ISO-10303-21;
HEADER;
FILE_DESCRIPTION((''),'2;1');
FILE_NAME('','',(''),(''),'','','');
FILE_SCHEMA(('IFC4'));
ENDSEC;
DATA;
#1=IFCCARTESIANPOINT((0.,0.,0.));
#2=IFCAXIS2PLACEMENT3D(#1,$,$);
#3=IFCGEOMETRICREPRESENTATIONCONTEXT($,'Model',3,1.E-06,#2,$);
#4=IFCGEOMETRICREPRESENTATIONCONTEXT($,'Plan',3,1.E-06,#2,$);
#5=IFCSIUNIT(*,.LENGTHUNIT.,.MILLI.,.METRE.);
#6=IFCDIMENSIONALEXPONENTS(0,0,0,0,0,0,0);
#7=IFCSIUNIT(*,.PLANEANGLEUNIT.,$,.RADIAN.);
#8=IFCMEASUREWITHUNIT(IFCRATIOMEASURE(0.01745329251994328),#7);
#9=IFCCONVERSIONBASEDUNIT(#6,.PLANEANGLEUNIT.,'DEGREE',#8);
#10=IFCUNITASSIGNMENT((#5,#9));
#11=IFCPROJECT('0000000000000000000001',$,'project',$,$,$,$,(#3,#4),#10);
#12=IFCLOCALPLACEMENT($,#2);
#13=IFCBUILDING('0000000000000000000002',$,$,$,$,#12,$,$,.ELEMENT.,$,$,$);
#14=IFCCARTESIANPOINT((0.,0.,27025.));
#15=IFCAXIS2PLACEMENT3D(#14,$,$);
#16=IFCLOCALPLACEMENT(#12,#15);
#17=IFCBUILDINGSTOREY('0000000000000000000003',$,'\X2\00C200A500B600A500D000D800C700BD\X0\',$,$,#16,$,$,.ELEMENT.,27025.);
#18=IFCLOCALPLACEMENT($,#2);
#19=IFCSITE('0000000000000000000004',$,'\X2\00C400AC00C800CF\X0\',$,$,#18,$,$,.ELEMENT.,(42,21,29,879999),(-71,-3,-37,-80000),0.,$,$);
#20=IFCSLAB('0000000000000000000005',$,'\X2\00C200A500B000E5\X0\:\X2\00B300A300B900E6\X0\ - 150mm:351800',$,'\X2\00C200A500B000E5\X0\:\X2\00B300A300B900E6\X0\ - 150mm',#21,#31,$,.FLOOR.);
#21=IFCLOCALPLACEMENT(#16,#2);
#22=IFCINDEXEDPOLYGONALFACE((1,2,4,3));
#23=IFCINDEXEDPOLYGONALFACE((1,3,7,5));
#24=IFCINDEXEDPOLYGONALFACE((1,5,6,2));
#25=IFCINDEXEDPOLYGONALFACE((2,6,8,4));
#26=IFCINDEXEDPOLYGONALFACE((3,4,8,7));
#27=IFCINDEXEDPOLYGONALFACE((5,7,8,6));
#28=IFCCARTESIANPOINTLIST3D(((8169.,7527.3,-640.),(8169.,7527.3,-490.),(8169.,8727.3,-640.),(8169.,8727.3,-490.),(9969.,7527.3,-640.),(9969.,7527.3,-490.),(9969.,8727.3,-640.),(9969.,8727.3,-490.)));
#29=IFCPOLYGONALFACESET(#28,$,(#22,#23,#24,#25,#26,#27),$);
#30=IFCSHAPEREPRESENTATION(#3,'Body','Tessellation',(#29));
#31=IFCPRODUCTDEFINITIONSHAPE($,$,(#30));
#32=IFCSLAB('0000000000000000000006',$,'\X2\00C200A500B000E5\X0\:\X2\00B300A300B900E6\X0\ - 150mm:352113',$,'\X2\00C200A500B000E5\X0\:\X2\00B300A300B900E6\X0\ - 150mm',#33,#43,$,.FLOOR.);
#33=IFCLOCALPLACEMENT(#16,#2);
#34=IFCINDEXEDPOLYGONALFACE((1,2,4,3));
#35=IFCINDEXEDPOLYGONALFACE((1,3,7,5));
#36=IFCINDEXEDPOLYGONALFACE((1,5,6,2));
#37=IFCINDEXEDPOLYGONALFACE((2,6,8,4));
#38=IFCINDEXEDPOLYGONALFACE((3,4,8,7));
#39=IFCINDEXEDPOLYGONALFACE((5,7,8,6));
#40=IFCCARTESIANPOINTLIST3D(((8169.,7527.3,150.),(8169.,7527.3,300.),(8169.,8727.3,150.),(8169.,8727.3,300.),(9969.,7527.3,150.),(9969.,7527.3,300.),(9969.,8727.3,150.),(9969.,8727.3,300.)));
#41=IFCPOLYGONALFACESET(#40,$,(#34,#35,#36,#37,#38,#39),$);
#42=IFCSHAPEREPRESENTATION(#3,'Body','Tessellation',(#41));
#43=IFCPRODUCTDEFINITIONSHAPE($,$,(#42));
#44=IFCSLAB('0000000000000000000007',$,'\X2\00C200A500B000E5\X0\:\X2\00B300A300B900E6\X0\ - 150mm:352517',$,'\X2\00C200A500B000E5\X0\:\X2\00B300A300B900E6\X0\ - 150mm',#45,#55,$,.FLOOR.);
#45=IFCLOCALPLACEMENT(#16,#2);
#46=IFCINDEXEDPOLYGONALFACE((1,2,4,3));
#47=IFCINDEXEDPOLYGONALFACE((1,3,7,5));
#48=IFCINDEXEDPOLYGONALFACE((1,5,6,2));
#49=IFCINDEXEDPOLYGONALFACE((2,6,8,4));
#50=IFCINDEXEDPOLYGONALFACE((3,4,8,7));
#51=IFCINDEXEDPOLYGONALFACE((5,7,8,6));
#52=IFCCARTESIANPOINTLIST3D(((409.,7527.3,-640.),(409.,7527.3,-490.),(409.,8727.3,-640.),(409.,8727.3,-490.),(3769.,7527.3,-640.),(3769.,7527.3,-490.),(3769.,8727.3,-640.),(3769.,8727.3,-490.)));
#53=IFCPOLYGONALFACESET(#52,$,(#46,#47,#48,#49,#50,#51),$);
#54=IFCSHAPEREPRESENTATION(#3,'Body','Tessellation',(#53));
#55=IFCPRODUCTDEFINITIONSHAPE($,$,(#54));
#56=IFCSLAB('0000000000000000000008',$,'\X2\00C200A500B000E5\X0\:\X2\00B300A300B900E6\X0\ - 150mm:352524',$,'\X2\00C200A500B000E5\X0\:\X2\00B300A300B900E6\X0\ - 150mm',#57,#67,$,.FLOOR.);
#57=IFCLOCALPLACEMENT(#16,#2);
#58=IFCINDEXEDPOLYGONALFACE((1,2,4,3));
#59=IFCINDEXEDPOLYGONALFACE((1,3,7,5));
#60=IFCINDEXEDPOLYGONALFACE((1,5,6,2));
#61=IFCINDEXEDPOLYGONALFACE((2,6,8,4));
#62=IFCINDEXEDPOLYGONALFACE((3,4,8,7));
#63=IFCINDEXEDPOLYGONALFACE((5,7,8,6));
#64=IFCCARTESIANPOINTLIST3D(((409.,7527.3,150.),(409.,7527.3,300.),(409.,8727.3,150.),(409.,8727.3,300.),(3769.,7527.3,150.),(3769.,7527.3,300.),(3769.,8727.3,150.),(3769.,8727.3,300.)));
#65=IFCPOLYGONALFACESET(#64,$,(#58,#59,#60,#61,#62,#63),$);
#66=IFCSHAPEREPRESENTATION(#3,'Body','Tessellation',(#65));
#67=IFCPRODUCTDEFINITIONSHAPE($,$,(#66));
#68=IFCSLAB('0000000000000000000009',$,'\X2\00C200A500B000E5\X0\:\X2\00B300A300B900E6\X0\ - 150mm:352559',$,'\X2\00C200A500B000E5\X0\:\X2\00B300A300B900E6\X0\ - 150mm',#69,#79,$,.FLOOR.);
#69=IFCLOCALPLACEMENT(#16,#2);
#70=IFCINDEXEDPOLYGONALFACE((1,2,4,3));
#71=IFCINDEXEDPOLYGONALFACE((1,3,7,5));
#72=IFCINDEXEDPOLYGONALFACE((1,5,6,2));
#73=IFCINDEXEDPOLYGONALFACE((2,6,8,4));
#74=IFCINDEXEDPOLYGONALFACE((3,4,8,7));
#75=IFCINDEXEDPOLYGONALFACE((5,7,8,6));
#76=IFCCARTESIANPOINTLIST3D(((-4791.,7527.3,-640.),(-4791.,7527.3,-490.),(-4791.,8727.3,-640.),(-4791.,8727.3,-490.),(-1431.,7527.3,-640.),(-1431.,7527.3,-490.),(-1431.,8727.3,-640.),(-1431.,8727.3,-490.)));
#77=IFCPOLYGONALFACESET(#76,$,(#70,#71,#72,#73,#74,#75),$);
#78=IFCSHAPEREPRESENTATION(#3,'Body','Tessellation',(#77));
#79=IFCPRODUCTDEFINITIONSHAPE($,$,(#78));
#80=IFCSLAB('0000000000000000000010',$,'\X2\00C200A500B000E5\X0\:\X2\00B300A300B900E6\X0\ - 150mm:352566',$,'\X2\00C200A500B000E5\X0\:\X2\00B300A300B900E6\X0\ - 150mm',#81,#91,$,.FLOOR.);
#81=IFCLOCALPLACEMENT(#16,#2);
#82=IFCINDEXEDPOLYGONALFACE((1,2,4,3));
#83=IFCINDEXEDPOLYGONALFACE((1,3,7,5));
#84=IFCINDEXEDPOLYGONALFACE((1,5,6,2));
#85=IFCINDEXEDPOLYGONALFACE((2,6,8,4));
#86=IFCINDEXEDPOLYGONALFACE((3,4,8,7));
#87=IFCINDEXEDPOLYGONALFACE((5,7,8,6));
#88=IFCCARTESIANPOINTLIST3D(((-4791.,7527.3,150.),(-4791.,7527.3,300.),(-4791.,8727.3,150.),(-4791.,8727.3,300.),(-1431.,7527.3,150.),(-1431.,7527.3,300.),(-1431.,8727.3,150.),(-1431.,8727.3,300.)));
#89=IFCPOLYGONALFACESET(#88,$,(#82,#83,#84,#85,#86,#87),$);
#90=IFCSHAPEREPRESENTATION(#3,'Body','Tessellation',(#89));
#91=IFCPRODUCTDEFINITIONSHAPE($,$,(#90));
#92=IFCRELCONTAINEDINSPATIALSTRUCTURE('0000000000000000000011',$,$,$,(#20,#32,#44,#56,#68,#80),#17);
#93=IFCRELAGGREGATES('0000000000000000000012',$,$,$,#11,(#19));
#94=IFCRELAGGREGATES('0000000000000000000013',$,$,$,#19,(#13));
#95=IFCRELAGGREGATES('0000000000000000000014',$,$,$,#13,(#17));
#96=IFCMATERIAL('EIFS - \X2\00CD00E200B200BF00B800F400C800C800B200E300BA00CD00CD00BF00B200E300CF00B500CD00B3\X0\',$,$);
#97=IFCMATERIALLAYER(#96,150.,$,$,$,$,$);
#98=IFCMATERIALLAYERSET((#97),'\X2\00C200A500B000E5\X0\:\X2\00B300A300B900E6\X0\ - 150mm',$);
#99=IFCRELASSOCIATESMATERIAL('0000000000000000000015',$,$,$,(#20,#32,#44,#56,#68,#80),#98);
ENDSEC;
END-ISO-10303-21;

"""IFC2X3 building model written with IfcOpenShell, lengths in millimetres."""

from ifc_helpers import new_model, entity, si_unit, converted_unit, frame, frame_2d, origin, place, context, project, spatial, rectangle, extrude, material, layer, layer_set, layer_usage, element, save


model = new_model("IFC2X3")

# Units and contexts
model_context = context("Model", 3, precision=1e-06, world=origin())
plan_context = context("Plan", 3, precision=1e-06, world=origin())
ifc_project = project(units=[si_unit("LENGTHUNIT", "METRE", prefix="MILLI"), converted_unit("PLANEANGLEUNIT", "DEGREE", entity("IfcRatioMeasure", 0.01745329251994328), si_unit("PLANEANGLEUNIT", "RADIAN"), dimensions=[0, 0, 0, 0, 0, 0, 0])], contexts=[model_context, plan_context])

# Site, building, storey
site_placement = place(None, origin())
site = spatial("IfcSite", under=ifc_project, at=site_placement, Name="Ä¬ÈÏ", CompositionType="ELEMENT", RefLatitude=(42, 21, 29, 879999), RefLongitude=(-71, -3, -37, -80000), RefElevation=0.0)
building_placement = place(None, origin())
building = spatial("IfcBuilding", under=site, at=building_placement, CompositionType="ELEMENT")
storey_placement = place(building_placement, frame((0.0, 0.0, 27025.0)))
storey = spatial("IfcBuildingStorey", under=building, at=storey_placement, Name="Â¥¶¥ÐØÇ½", CompositionType="ELEMENT", Elevation=27025.0)

# Slabs
ifc_material = material(Name="EIFS - Íâ²¿¸ôÈÈ²ãºÍÍ¿²ãÏµÍ³")
ifc_layer = layer(ifc_material, 150.0)
ifc_layer_set = layer_set([ifc_layer], Name="Â¥°å:³£¹æ - 150mm")
ifc_layer_usage_1 = layer_usage(ifc_layer_set, "AXIS3", "POSITIVE", 0.0)
slab_1_placement = place(storey_placement, frame((8169.0, 7527.3, -640.0)))
element("IfcSlab", 1, at=slab_1_placement, inside=storey, material=ifc_layer_usage_1, Name="Â¥°å:³£¹æ - 150mm:351800", ObjectType="Â¥°å:³£¹æ - 150mm", PredefinedType="FLOOR", context=model_context, shape_type="SweptSolid", body=[
    extrude(rectangle(XDim=1200.0, YDim=1800.0, at=frame_2d((-9069.0, 8127.3), x_axis=(0.0, 1.0))), frame((-8169.0, -7527.3, 150.0), z_axis=(0.0, 0.0, -1.0), x_axis=(-1.0, 0.0, 0.0)), (0.0, 0.0, 1.0), 150.0),
])
ifc_layer_usage_2 = layer_usage(ifc_layer_set, "AXIS3", "POSITIVE", 0.0)
slab_2_placement = place(storey_placement, frame((8169.0, 7527.3, 150.0)))
element("IfcSlab", 2, at=slab_2_placement, inside=storey, material=ifc_layer_usage_2, Name="Â¥°å:³£¹æ - 150mm:352113", ObjectType="Â¥°å:³£¹æ - 150mm", PredefinedType="FLOOR", context=model_context, shape_type="SweptSolid", body=[
    extrude(rectangle(XDim=1200.0, YDim=1800.0, at=frame_2d((-9069.0, 8127.3), x_axis=(0.0, 1.0))), frame((-8169.0, -7527.3, 150.0), z_axis=(0.0, 0.0, -1.0), x_axis=(-1.0, 0.0, 0.0)), (0.0, 0.0, 1.0), 150.0),
])
ifc_layer_usage_3 = layer_usage(ifc_layer_set, "AXIS3", "POSITIVE", 0.0)
slab_3_placement = place(storey_placement, frame((409.0, 7527.3, -640.0)))
element("IfcSlab", 3, at=slab_3_placement, inside=storey, material=ifc_layer_usage_3, Name="Â¥°å:³£¹æ - 150mm:352517", ObjectType="Â¥°å:³£¹æ - 150mm", PredefinedType="FLOOR", context=model_context, shape_type="SweptSolid", body=[
    extrude(rectangle(XDim=1200.0, YDim=3360.0, at=frame_2d((-2089.0, 8127.3), x_axis=(0.0, 1.0))), frame((-409.0, -7527.3, 150.0), z_axis=(0.0, 0.0, -1.0), x_axis=(-1.0, 0.0, 0.0)), (0.0, 0.0, 1.0), 150.0),
])
ifc_layer_usage_4 = layer_usage(ifc_layer_set, "AXIS3", "POSITIVE", 0.0)
slab_4_placement = place(storey_placement, frame((409.0, 7527.3, 150.0)))
element("IfcSlab", 4, at=slab_4_placement, inside=storey, material=ifc_layer_usage_4, Name="Â¥°å:³£¹æ - 150mm:352524", ObjectType="Â¥°å:³£¹æ - 150mm", PredefinedType="FLOOR", context=model_context, shape_type="SweptSolid", body=[
    extrude(rectangle(XDim=1200.0, YDim=3360.0, at=frame_2d((-2089.0, 8127.3), x_axis=(0.0, 1.0))), frame((-409.0, -7527.3, 150.0), z_axis=(0.0, 0.0, -1.0), x_axis=(-1.0, 0.0, 0.0)), (0.0, 0.0, 1.0), 150.0),
])
ifc_layer_usage_5 = layer_usage(ifc_layer_set, "AXIS3", "POSITIVE", 0.0)
slab_5_placement = place(storey_placement, frame((-4791.0, 7527.3, -640.0)))
element("IfcSlab", 5, at=slab_5_placement, inside=storey, material=ifc_layer_usage_5, Name="Â¥°å:³£¹æ - 150mm:352559", ObjectType="Â¥°å:³£¹æ - 150mm", PredefinedType="FLOOR", context=model_context, shape_type="SweptSolid", body=[
    extrude(rectangle(XDim=1200.0, YDim=3360.0, at=frame_2d((3111.0, 8127.3), x_axis=(0.0, 1.0))), frame((4791.0, -7527.3, 150.0), z_axis=(0.0, 0.0, -1.0), x_axis=(-1.0, 0.0, 0.0)), (0.0, 0.0, 1.0), 150.0),
])
ifc_layer_usage_6 = layer_usage(ifc_layer_set, "AXIS3", "POSITIVE", 0.0)
slab_6_placement = place(storey_placement, frame((-4791.0, 7527.3, 150.0)))
element("IfcSlab", 6, at=slab_6_placement, inside=storey, material=ifc_layer_usage_6, Name="Â¥°å:³£¹æ - 150mm:352566", ObjectType="Â¥°å:³£¹æ - 150mm", PredefinedType="FLOOR", context=model_context, shape_type="SweptSolid", body=[
    extrude(rectangle(XDim=1200.0, YDim=3360.0, at=frame_2d((3111.0, 8127.3), x_axis=(0.0, 1.0))), frame((4791.0, -7527.3, 150.0), z_axis=(0.0, 0.0, -1.0), x_axis=(-1.0, 0.0, 0.0)), (0.0, 0.0, 1.0), 150.0),
])

save(model, "model.ifc")
